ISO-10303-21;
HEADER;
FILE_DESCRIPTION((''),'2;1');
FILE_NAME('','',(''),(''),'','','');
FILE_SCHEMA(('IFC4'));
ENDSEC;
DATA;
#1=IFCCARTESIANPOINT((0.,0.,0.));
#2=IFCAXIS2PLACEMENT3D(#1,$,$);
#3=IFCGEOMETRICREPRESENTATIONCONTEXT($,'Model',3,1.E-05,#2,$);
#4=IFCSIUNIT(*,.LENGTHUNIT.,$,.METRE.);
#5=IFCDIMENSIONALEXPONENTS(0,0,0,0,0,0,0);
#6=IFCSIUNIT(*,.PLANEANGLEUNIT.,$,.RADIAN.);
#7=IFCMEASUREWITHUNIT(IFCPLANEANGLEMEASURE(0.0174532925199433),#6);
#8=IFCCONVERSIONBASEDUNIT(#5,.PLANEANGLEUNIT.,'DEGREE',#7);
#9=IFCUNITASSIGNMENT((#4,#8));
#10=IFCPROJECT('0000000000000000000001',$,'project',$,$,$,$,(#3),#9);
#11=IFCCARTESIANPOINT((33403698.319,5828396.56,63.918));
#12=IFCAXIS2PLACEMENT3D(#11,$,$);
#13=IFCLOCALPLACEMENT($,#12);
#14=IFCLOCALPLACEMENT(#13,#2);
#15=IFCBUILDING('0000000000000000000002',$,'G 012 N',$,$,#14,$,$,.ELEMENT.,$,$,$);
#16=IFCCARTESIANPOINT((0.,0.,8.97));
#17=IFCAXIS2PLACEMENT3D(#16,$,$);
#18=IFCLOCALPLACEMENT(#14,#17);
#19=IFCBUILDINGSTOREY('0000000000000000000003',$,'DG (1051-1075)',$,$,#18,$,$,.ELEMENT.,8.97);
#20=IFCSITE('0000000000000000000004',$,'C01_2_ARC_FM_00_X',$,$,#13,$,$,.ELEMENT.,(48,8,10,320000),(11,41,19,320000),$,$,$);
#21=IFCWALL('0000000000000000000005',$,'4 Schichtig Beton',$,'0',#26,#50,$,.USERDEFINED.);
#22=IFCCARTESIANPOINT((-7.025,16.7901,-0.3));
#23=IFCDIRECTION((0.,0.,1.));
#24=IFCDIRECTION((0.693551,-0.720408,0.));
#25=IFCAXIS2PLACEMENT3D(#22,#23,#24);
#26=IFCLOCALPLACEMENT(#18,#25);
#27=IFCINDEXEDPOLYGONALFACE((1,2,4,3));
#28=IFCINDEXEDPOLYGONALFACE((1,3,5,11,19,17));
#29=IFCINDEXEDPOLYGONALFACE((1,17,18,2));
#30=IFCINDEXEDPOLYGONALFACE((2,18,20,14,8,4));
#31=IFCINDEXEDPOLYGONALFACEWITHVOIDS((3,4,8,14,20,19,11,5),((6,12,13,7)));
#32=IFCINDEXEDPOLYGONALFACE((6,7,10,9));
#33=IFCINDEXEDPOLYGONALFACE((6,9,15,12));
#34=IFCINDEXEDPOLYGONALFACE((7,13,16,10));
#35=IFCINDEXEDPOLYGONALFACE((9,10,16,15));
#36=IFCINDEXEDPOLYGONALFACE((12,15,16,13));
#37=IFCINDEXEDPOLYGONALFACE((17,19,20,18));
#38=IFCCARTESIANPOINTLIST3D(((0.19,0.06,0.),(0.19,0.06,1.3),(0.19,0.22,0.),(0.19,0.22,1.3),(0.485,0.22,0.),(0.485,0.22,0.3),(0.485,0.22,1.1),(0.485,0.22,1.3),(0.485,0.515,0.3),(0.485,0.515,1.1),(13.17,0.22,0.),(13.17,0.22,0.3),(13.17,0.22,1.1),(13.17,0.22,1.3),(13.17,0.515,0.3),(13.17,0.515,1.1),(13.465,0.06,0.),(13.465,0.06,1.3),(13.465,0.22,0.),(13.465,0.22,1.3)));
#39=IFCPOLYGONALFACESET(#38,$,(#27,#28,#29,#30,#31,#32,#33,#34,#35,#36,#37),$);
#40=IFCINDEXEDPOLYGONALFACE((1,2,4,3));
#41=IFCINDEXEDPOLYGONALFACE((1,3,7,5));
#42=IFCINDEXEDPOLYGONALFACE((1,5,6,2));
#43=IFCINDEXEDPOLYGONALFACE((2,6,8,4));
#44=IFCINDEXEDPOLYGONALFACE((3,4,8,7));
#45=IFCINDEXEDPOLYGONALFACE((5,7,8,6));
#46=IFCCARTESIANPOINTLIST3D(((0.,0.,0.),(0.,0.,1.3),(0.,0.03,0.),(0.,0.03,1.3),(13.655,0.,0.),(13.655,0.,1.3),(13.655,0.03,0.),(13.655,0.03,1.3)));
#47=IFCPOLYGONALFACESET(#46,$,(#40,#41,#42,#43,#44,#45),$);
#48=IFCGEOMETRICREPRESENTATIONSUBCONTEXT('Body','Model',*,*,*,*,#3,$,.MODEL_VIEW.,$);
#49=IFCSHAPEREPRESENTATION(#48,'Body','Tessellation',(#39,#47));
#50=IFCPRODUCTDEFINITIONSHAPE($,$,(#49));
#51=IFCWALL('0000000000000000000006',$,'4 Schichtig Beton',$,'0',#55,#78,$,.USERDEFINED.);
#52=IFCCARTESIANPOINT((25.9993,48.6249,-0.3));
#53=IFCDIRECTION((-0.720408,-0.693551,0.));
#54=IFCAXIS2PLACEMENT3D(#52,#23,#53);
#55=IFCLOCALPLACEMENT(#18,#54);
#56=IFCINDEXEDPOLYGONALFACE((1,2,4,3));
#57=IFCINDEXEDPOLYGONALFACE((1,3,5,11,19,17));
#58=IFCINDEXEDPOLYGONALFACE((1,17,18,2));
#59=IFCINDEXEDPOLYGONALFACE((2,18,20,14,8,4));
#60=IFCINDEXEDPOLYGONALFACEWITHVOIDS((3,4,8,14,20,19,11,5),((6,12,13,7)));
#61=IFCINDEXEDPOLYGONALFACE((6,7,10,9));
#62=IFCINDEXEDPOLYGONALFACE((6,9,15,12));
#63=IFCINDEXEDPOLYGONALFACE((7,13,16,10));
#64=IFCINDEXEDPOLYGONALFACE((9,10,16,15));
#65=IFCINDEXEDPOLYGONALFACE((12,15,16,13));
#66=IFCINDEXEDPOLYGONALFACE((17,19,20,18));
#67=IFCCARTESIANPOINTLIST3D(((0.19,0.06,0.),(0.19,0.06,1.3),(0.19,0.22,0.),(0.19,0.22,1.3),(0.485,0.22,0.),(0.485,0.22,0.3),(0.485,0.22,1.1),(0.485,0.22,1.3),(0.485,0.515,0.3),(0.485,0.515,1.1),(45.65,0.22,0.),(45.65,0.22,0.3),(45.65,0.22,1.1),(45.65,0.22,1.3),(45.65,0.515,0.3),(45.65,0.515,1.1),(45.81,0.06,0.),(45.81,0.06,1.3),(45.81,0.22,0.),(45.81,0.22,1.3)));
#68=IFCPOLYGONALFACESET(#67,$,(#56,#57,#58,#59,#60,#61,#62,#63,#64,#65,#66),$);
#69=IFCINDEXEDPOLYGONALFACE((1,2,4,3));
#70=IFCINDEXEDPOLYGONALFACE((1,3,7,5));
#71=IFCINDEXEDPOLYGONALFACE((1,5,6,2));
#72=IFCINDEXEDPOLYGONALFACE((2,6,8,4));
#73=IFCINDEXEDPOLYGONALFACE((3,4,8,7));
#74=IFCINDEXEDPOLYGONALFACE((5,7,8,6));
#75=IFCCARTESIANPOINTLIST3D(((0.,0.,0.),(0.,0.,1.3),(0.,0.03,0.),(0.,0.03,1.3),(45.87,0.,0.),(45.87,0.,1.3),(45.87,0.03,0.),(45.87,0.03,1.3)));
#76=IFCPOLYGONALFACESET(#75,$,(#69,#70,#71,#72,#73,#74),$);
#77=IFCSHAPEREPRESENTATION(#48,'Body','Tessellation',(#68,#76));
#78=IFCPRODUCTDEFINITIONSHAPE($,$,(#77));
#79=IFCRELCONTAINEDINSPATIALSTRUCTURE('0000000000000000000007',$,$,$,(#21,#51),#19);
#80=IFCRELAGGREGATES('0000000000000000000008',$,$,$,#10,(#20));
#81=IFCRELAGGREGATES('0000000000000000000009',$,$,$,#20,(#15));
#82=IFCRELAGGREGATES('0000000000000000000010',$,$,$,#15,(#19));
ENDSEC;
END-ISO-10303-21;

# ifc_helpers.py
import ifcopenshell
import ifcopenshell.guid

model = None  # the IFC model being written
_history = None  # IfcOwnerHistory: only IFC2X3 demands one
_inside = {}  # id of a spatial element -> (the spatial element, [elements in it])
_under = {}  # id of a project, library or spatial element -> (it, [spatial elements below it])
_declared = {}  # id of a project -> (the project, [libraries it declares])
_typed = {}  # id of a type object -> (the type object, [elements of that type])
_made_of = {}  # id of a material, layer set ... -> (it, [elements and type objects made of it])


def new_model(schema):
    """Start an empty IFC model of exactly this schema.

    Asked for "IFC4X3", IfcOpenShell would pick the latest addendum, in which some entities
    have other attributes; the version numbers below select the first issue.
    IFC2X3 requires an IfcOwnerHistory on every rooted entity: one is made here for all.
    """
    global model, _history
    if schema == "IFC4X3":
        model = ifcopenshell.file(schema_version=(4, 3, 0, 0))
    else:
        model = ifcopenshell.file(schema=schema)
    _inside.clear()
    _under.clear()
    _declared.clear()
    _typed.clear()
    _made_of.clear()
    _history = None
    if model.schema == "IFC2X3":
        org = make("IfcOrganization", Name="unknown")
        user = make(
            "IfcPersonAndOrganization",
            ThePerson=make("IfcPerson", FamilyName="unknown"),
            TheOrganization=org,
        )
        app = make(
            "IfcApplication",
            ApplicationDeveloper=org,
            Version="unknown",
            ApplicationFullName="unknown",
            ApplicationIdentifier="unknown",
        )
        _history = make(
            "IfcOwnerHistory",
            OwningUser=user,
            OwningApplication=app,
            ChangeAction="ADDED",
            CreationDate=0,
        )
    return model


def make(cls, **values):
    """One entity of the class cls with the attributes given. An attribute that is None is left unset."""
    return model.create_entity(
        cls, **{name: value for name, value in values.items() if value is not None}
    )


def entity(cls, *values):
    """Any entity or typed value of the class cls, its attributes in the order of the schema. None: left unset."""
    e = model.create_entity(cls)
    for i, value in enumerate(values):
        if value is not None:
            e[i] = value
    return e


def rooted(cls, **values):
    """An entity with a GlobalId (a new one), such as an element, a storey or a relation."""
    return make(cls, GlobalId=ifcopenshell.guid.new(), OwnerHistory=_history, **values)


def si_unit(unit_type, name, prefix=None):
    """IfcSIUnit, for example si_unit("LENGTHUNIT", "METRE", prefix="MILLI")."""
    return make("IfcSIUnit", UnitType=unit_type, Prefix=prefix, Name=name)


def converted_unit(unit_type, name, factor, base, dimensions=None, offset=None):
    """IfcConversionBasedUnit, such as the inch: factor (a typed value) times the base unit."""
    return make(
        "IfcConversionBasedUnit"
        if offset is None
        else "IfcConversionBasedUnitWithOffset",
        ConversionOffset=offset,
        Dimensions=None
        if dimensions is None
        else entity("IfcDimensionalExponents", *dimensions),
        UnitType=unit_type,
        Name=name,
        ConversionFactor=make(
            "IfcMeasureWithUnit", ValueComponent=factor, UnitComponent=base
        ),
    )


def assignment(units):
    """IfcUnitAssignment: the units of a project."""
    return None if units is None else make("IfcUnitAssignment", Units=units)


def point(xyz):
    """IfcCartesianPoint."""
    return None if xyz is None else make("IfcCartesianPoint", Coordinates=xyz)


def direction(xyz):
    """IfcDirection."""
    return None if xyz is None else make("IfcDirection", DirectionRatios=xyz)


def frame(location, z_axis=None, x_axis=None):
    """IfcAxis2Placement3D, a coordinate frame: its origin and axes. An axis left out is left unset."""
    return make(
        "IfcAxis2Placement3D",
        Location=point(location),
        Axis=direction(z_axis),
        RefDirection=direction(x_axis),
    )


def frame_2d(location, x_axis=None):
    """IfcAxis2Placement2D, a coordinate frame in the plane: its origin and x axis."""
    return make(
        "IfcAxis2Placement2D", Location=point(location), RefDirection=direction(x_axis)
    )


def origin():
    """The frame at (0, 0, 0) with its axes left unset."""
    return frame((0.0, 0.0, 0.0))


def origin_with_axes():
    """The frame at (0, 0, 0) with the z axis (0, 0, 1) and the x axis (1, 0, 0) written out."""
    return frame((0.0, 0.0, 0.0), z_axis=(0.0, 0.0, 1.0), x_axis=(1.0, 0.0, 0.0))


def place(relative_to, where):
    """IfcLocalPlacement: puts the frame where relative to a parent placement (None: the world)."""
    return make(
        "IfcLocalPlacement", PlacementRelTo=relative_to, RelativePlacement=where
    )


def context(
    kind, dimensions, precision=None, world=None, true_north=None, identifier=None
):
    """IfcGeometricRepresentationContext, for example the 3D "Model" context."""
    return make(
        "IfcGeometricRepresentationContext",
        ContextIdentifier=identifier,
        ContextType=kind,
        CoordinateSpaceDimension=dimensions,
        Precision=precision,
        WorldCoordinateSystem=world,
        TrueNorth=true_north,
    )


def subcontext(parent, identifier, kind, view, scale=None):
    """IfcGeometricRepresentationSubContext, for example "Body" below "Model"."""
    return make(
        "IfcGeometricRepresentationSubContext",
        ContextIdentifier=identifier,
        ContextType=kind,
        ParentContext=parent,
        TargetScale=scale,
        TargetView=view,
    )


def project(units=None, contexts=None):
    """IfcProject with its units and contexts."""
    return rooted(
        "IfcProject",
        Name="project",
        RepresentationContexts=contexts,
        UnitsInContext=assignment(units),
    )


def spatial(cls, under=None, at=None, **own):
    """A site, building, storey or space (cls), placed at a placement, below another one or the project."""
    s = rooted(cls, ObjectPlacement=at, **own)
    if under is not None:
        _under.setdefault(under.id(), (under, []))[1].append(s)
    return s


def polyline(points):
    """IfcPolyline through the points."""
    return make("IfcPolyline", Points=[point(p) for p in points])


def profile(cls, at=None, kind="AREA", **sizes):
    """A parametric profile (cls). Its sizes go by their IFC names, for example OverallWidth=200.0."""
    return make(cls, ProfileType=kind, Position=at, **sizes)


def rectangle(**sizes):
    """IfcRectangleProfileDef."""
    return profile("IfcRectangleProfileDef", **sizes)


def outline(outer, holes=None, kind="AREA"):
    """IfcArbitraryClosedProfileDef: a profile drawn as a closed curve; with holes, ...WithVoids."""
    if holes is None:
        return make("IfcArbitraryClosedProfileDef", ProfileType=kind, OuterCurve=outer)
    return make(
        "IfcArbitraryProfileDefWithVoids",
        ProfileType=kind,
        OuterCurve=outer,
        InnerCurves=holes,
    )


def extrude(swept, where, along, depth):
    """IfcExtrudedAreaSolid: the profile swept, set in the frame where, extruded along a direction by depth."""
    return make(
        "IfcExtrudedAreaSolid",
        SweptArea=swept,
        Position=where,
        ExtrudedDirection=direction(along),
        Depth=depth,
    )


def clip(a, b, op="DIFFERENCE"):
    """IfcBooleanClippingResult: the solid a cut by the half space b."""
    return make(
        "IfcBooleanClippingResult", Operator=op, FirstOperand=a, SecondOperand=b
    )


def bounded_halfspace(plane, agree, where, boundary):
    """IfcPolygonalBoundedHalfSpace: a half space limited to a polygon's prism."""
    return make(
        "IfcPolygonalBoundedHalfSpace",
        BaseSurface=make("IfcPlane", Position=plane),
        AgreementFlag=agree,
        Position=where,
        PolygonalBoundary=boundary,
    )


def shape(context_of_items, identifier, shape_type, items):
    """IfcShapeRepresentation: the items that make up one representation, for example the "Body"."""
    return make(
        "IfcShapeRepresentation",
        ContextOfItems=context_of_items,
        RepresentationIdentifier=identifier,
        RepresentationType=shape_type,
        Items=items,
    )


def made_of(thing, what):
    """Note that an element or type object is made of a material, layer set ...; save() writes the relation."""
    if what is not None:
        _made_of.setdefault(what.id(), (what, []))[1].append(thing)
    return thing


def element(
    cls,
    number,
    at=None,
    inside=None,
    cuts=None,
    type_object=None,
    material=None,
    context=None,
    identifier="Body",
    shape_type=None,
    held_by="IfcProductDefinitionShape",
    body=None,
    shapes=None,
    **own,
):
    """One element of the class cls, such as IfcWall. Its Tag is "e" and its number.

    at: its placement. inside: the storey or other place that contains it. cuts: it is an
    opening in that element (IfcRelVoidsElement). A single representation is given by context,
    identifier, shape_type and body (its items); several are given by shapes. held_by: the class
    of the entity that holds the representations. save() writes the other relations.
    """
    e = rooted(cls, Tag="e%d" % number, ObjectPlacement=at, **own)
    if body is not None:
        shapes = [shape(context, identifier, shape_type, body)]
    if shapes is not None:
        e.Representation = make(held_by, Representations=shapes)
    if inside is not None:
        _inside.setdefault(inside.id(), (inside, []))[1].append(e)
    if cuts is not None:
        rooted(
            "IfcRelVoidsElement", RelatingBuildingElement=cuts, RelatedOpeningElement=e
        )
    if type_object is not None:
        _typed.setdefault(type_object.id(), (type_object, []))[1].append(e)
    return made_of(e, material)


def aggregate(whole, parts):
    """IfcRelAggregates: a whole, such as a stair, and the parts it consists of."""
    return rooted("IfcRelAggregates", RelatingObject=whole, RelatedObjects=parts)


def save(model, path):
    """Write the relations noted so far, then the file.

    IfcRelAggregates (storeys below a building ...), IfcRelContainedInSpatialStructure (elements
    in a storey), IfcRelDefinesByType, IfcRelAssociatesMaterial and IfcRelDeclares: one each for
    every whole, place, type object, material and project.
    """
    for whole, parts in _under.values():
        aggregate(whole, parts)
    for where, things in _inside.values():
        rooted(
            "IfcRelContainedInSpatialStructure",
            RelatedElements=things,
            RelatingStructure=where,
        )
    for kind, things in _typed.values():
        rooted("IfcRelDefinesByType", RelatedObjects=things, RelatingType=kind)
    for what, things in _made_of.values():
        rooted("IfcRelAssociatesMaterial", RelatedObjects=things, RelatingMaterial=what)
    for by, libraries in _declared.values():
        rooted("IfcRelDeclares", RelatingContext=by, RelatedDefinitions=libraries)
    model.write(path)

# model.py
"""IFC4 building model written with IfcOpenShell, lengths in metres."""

from ifc_helpers import new_model, entity, si_unit, converted_unit, frame, frame_2d, origin, origin_with_axes, place, context, subcontext, project, spatial, polyline, rectangle, outline, extrude, clip, bounded_halfspace, element, save


model = new_model("IFC4")

# Units and contexts
model_context = context("Model", 3, precision=1e-05, world=origin())
body_context = subcontext(model_context, "Body", "Model", "MODEL_VIEW")
ifc_project = project(units=[si_unit("LENGTHUNIT", "METRE"), converted_unit("PLANEANGLEUNIT", "DEGREE", entity("IfcPlaneAngleMeasure", 0.0174532925199433), si_unit("PLANEANGLEUNIT", "RADIAN"), dimensions=[0, 0, 0, 0, 0, 0, 0])], contexts=[model_context])

# Site, building, storey
site_placement = place(None, frame((33403698.319, 5828396.56, 63.918)))
site = spatial("IfcSite", under=ifc_project, at=site_placement, Name="C01_2_ARC_FM_00_X", CompositionType="ELEMENT", RefLatitude=(48, 8, 10, 320000), RefLongitude=(11, 41, 19, 320000))
building_placement = place(site_placement, origin())
building = spatial("IfcBuilding", under=site, at=building_placement, Name="G 012 N", CompositionType="ELEMENT")
storey_placement = place(building_placement, frame((0.0, 0.0, 8.97)))
storey = spatial("IfcBuildingStorey", under=building, at=storey_placement, Name="DG (1051-1075)", CompositionType="ELEMENT", Elevation=8.97)

# Walls
wall_1_placement = place(storey_placement, frame((-7.025, 16.7901, -0.3), z_axis=(0.0, 0.0, 1.0), x_axis=(0.693551, -0.720408, 0.0)))
element("IfcWall", 1, at=wall_1_placement, inside=storey, Name="4 Schichtig Beton", ObjectType="0", PredefinedType="USERDEFINED", context=body_context, shape_type="Clipping", body=[
    clip(clip(extrude(outline(polyline([(6.0904, 6.7927), (6.0904, 7.0877), (-6.5946, 7.0877), (-6.5946, 6.7927), (-6.8896, 6.7927), (-6.8896, 6.6327), (6.3854, 6.6327), (6.3854, 6.7927), (6.0904, 6.7927)])), frame((7.0796, -6.5727, 0.0), z_axis=(0.0, 0.0, 1.0), x_axis=(1.0, 0.0, 0.0)), (0.0, 0.0, 1.0), 1.3), bounded_halfspace(frame((6.8275, 0.3675, 0.3), z_axis=(0.0, 0.0, 1.0), x_axis=(0.0, -1.0, 0.0)), True, origin_with_axes(), polyline([(0.485, 0.515), (0.485, 0.22), (13.17, 0.22), (13.17, 0.515), (0.485, 0.515)]))), bounded_halfspace(frame((6.8275, 0.3675, 1.1), z_axis=(0.0, 0.0, -1.0), x_axis=(1.0, 0.0, 0.0)), True, origin_with_axes(), polyline([(0.485, 0.22), (13.17, 0.22), (13.17, 0.515), (0.485, 0.515), (0.485, 0.22)]))),
    clip(clip(extrude(rectangle(XDim=13.655, YDim=0.03, at=frame_2d((-6.8275, -0.015), x_axis=(-1.0, 0.0))), frame((13.655, 0.03, 0.0), z_axis=(0.0, 0.0, 1.0), x_axis=(1.0, 0.0, 0.0)), (0.0, 0.0, 1.0), 1.3), bounded_halfspace(frame((6.8275, 0.3675, 0.3), z_axis=(0.0, 0.0, 1.0), x_axis=(0.0, -1.0, 0.0)), True, origin_with_axes(), polyline([(0.485, 0.515), (0.485, 0.22), (13.17, 0.22), (13.17, 0.515), (0.485, 0.515)]))), bounded_halfspace(frame((6.8275, 0.3675, 1.1), z_axis=(0.0, 0.0, -1.0), x_axis=(1.0, 0.0, 0.0)), True, origin_with_axes(), polyline([(0.485, 0.22), (13.17, 0.22), (13.17, 0.515), (0.485, 0.515), (0.485, 0.22)]))),
])
wall_2_placement = place(storey_placement, frame((25.9993, 48.6249, -0.3), z_axis=(0.0, 0.0, 1.0), x_axis=(-0.720408, -0.693551, 0.0)))
element("IfcWall", 2, at=wall_2_placement, inside=storey, Name="4 Schichtig Beton", ObjectType="0", PredefinedType="USERDEFINED", context=body_context, shape_type="Clipping", body=[
    clip(clip(extrude(outline(polyline([(-0.3104, 0.0038), (-0.3104, 0.2988), (-45.4754, 0.2988), (-45.4754, 0.0038), (-45.7704, 0.0038), (-45.7704, -0.1562), (-0.1504, -0.1562), (-0.1504, 0.0038), (-0.3104, 0.0038)])), frame((45.9604, 0.2162, 0.0), z_axis=(0.0, 0.0, 1.0), x_axis=(1.0, 0.0, 0.0)), (0.0, 0.0, 1.0), 1.3), bounded_halfspace(frame((23.0675, 0.3675, 0.3), z_axis=(0.0, 0.0, 1.0), x_axis=(0.0, -1.0, 0.0)), True, origin_with_axes(), polyline([(0.485, 0.515), (0.485, 0.22), (45.65, 0.22), (45.65, 0.515), (0.485, 0.515)]))), bounded_halfspace(frame((23.0675, 0.3675, 1.1), z_axis=(0.0, 0.0, -1.0), x_axis=(1.0, 0.0, 0.0)), True, origin_with_axes(), polyline([(0.485, 0.22), (45.65, 0.22), (45.65, 0.515), (0.485, 0.515), (0.485, 0.22)]))),
    clip(clip(extrude(rectangle(XDim=45.87, YDim=0.03, at=frame_2d((-22.935, -0.015), x_axis=(-1.0, 0.0))), frame((45.87, 0.03, 0.0), z_axis=(0.0, 0.0, 1.0), x_axis=(1.0, 0.0, 0.0)), (0.0, 0.0, 1.0), 1.3), bounded_halfspace(frame((23.0675, 0.3675, 0.3), z_axis=(0.0, 0.0, 1.0), x_axis=(0.0, -1.0, 0.0)), True, origin_with_axes(), polyline([(0.485, 0.515), (0.485, 0.22), (45.65, 0.22), (45.65, 0.515), (0.485, 0.515)]))), bounded_halfspace(frame((23.0675, 0.3675, 1.1), z_axis=(0.0, 0.0, -1.0), x_axis=(1.0, 0.0, 0.0)), True, origin_with_axes(), polyline([(0.485, 0.22), (45.65, 0.22), (45.65, 0.515), (0.485, 0.515), (0.485, 0.22)]))),
])

save(model, "model.ifc")
